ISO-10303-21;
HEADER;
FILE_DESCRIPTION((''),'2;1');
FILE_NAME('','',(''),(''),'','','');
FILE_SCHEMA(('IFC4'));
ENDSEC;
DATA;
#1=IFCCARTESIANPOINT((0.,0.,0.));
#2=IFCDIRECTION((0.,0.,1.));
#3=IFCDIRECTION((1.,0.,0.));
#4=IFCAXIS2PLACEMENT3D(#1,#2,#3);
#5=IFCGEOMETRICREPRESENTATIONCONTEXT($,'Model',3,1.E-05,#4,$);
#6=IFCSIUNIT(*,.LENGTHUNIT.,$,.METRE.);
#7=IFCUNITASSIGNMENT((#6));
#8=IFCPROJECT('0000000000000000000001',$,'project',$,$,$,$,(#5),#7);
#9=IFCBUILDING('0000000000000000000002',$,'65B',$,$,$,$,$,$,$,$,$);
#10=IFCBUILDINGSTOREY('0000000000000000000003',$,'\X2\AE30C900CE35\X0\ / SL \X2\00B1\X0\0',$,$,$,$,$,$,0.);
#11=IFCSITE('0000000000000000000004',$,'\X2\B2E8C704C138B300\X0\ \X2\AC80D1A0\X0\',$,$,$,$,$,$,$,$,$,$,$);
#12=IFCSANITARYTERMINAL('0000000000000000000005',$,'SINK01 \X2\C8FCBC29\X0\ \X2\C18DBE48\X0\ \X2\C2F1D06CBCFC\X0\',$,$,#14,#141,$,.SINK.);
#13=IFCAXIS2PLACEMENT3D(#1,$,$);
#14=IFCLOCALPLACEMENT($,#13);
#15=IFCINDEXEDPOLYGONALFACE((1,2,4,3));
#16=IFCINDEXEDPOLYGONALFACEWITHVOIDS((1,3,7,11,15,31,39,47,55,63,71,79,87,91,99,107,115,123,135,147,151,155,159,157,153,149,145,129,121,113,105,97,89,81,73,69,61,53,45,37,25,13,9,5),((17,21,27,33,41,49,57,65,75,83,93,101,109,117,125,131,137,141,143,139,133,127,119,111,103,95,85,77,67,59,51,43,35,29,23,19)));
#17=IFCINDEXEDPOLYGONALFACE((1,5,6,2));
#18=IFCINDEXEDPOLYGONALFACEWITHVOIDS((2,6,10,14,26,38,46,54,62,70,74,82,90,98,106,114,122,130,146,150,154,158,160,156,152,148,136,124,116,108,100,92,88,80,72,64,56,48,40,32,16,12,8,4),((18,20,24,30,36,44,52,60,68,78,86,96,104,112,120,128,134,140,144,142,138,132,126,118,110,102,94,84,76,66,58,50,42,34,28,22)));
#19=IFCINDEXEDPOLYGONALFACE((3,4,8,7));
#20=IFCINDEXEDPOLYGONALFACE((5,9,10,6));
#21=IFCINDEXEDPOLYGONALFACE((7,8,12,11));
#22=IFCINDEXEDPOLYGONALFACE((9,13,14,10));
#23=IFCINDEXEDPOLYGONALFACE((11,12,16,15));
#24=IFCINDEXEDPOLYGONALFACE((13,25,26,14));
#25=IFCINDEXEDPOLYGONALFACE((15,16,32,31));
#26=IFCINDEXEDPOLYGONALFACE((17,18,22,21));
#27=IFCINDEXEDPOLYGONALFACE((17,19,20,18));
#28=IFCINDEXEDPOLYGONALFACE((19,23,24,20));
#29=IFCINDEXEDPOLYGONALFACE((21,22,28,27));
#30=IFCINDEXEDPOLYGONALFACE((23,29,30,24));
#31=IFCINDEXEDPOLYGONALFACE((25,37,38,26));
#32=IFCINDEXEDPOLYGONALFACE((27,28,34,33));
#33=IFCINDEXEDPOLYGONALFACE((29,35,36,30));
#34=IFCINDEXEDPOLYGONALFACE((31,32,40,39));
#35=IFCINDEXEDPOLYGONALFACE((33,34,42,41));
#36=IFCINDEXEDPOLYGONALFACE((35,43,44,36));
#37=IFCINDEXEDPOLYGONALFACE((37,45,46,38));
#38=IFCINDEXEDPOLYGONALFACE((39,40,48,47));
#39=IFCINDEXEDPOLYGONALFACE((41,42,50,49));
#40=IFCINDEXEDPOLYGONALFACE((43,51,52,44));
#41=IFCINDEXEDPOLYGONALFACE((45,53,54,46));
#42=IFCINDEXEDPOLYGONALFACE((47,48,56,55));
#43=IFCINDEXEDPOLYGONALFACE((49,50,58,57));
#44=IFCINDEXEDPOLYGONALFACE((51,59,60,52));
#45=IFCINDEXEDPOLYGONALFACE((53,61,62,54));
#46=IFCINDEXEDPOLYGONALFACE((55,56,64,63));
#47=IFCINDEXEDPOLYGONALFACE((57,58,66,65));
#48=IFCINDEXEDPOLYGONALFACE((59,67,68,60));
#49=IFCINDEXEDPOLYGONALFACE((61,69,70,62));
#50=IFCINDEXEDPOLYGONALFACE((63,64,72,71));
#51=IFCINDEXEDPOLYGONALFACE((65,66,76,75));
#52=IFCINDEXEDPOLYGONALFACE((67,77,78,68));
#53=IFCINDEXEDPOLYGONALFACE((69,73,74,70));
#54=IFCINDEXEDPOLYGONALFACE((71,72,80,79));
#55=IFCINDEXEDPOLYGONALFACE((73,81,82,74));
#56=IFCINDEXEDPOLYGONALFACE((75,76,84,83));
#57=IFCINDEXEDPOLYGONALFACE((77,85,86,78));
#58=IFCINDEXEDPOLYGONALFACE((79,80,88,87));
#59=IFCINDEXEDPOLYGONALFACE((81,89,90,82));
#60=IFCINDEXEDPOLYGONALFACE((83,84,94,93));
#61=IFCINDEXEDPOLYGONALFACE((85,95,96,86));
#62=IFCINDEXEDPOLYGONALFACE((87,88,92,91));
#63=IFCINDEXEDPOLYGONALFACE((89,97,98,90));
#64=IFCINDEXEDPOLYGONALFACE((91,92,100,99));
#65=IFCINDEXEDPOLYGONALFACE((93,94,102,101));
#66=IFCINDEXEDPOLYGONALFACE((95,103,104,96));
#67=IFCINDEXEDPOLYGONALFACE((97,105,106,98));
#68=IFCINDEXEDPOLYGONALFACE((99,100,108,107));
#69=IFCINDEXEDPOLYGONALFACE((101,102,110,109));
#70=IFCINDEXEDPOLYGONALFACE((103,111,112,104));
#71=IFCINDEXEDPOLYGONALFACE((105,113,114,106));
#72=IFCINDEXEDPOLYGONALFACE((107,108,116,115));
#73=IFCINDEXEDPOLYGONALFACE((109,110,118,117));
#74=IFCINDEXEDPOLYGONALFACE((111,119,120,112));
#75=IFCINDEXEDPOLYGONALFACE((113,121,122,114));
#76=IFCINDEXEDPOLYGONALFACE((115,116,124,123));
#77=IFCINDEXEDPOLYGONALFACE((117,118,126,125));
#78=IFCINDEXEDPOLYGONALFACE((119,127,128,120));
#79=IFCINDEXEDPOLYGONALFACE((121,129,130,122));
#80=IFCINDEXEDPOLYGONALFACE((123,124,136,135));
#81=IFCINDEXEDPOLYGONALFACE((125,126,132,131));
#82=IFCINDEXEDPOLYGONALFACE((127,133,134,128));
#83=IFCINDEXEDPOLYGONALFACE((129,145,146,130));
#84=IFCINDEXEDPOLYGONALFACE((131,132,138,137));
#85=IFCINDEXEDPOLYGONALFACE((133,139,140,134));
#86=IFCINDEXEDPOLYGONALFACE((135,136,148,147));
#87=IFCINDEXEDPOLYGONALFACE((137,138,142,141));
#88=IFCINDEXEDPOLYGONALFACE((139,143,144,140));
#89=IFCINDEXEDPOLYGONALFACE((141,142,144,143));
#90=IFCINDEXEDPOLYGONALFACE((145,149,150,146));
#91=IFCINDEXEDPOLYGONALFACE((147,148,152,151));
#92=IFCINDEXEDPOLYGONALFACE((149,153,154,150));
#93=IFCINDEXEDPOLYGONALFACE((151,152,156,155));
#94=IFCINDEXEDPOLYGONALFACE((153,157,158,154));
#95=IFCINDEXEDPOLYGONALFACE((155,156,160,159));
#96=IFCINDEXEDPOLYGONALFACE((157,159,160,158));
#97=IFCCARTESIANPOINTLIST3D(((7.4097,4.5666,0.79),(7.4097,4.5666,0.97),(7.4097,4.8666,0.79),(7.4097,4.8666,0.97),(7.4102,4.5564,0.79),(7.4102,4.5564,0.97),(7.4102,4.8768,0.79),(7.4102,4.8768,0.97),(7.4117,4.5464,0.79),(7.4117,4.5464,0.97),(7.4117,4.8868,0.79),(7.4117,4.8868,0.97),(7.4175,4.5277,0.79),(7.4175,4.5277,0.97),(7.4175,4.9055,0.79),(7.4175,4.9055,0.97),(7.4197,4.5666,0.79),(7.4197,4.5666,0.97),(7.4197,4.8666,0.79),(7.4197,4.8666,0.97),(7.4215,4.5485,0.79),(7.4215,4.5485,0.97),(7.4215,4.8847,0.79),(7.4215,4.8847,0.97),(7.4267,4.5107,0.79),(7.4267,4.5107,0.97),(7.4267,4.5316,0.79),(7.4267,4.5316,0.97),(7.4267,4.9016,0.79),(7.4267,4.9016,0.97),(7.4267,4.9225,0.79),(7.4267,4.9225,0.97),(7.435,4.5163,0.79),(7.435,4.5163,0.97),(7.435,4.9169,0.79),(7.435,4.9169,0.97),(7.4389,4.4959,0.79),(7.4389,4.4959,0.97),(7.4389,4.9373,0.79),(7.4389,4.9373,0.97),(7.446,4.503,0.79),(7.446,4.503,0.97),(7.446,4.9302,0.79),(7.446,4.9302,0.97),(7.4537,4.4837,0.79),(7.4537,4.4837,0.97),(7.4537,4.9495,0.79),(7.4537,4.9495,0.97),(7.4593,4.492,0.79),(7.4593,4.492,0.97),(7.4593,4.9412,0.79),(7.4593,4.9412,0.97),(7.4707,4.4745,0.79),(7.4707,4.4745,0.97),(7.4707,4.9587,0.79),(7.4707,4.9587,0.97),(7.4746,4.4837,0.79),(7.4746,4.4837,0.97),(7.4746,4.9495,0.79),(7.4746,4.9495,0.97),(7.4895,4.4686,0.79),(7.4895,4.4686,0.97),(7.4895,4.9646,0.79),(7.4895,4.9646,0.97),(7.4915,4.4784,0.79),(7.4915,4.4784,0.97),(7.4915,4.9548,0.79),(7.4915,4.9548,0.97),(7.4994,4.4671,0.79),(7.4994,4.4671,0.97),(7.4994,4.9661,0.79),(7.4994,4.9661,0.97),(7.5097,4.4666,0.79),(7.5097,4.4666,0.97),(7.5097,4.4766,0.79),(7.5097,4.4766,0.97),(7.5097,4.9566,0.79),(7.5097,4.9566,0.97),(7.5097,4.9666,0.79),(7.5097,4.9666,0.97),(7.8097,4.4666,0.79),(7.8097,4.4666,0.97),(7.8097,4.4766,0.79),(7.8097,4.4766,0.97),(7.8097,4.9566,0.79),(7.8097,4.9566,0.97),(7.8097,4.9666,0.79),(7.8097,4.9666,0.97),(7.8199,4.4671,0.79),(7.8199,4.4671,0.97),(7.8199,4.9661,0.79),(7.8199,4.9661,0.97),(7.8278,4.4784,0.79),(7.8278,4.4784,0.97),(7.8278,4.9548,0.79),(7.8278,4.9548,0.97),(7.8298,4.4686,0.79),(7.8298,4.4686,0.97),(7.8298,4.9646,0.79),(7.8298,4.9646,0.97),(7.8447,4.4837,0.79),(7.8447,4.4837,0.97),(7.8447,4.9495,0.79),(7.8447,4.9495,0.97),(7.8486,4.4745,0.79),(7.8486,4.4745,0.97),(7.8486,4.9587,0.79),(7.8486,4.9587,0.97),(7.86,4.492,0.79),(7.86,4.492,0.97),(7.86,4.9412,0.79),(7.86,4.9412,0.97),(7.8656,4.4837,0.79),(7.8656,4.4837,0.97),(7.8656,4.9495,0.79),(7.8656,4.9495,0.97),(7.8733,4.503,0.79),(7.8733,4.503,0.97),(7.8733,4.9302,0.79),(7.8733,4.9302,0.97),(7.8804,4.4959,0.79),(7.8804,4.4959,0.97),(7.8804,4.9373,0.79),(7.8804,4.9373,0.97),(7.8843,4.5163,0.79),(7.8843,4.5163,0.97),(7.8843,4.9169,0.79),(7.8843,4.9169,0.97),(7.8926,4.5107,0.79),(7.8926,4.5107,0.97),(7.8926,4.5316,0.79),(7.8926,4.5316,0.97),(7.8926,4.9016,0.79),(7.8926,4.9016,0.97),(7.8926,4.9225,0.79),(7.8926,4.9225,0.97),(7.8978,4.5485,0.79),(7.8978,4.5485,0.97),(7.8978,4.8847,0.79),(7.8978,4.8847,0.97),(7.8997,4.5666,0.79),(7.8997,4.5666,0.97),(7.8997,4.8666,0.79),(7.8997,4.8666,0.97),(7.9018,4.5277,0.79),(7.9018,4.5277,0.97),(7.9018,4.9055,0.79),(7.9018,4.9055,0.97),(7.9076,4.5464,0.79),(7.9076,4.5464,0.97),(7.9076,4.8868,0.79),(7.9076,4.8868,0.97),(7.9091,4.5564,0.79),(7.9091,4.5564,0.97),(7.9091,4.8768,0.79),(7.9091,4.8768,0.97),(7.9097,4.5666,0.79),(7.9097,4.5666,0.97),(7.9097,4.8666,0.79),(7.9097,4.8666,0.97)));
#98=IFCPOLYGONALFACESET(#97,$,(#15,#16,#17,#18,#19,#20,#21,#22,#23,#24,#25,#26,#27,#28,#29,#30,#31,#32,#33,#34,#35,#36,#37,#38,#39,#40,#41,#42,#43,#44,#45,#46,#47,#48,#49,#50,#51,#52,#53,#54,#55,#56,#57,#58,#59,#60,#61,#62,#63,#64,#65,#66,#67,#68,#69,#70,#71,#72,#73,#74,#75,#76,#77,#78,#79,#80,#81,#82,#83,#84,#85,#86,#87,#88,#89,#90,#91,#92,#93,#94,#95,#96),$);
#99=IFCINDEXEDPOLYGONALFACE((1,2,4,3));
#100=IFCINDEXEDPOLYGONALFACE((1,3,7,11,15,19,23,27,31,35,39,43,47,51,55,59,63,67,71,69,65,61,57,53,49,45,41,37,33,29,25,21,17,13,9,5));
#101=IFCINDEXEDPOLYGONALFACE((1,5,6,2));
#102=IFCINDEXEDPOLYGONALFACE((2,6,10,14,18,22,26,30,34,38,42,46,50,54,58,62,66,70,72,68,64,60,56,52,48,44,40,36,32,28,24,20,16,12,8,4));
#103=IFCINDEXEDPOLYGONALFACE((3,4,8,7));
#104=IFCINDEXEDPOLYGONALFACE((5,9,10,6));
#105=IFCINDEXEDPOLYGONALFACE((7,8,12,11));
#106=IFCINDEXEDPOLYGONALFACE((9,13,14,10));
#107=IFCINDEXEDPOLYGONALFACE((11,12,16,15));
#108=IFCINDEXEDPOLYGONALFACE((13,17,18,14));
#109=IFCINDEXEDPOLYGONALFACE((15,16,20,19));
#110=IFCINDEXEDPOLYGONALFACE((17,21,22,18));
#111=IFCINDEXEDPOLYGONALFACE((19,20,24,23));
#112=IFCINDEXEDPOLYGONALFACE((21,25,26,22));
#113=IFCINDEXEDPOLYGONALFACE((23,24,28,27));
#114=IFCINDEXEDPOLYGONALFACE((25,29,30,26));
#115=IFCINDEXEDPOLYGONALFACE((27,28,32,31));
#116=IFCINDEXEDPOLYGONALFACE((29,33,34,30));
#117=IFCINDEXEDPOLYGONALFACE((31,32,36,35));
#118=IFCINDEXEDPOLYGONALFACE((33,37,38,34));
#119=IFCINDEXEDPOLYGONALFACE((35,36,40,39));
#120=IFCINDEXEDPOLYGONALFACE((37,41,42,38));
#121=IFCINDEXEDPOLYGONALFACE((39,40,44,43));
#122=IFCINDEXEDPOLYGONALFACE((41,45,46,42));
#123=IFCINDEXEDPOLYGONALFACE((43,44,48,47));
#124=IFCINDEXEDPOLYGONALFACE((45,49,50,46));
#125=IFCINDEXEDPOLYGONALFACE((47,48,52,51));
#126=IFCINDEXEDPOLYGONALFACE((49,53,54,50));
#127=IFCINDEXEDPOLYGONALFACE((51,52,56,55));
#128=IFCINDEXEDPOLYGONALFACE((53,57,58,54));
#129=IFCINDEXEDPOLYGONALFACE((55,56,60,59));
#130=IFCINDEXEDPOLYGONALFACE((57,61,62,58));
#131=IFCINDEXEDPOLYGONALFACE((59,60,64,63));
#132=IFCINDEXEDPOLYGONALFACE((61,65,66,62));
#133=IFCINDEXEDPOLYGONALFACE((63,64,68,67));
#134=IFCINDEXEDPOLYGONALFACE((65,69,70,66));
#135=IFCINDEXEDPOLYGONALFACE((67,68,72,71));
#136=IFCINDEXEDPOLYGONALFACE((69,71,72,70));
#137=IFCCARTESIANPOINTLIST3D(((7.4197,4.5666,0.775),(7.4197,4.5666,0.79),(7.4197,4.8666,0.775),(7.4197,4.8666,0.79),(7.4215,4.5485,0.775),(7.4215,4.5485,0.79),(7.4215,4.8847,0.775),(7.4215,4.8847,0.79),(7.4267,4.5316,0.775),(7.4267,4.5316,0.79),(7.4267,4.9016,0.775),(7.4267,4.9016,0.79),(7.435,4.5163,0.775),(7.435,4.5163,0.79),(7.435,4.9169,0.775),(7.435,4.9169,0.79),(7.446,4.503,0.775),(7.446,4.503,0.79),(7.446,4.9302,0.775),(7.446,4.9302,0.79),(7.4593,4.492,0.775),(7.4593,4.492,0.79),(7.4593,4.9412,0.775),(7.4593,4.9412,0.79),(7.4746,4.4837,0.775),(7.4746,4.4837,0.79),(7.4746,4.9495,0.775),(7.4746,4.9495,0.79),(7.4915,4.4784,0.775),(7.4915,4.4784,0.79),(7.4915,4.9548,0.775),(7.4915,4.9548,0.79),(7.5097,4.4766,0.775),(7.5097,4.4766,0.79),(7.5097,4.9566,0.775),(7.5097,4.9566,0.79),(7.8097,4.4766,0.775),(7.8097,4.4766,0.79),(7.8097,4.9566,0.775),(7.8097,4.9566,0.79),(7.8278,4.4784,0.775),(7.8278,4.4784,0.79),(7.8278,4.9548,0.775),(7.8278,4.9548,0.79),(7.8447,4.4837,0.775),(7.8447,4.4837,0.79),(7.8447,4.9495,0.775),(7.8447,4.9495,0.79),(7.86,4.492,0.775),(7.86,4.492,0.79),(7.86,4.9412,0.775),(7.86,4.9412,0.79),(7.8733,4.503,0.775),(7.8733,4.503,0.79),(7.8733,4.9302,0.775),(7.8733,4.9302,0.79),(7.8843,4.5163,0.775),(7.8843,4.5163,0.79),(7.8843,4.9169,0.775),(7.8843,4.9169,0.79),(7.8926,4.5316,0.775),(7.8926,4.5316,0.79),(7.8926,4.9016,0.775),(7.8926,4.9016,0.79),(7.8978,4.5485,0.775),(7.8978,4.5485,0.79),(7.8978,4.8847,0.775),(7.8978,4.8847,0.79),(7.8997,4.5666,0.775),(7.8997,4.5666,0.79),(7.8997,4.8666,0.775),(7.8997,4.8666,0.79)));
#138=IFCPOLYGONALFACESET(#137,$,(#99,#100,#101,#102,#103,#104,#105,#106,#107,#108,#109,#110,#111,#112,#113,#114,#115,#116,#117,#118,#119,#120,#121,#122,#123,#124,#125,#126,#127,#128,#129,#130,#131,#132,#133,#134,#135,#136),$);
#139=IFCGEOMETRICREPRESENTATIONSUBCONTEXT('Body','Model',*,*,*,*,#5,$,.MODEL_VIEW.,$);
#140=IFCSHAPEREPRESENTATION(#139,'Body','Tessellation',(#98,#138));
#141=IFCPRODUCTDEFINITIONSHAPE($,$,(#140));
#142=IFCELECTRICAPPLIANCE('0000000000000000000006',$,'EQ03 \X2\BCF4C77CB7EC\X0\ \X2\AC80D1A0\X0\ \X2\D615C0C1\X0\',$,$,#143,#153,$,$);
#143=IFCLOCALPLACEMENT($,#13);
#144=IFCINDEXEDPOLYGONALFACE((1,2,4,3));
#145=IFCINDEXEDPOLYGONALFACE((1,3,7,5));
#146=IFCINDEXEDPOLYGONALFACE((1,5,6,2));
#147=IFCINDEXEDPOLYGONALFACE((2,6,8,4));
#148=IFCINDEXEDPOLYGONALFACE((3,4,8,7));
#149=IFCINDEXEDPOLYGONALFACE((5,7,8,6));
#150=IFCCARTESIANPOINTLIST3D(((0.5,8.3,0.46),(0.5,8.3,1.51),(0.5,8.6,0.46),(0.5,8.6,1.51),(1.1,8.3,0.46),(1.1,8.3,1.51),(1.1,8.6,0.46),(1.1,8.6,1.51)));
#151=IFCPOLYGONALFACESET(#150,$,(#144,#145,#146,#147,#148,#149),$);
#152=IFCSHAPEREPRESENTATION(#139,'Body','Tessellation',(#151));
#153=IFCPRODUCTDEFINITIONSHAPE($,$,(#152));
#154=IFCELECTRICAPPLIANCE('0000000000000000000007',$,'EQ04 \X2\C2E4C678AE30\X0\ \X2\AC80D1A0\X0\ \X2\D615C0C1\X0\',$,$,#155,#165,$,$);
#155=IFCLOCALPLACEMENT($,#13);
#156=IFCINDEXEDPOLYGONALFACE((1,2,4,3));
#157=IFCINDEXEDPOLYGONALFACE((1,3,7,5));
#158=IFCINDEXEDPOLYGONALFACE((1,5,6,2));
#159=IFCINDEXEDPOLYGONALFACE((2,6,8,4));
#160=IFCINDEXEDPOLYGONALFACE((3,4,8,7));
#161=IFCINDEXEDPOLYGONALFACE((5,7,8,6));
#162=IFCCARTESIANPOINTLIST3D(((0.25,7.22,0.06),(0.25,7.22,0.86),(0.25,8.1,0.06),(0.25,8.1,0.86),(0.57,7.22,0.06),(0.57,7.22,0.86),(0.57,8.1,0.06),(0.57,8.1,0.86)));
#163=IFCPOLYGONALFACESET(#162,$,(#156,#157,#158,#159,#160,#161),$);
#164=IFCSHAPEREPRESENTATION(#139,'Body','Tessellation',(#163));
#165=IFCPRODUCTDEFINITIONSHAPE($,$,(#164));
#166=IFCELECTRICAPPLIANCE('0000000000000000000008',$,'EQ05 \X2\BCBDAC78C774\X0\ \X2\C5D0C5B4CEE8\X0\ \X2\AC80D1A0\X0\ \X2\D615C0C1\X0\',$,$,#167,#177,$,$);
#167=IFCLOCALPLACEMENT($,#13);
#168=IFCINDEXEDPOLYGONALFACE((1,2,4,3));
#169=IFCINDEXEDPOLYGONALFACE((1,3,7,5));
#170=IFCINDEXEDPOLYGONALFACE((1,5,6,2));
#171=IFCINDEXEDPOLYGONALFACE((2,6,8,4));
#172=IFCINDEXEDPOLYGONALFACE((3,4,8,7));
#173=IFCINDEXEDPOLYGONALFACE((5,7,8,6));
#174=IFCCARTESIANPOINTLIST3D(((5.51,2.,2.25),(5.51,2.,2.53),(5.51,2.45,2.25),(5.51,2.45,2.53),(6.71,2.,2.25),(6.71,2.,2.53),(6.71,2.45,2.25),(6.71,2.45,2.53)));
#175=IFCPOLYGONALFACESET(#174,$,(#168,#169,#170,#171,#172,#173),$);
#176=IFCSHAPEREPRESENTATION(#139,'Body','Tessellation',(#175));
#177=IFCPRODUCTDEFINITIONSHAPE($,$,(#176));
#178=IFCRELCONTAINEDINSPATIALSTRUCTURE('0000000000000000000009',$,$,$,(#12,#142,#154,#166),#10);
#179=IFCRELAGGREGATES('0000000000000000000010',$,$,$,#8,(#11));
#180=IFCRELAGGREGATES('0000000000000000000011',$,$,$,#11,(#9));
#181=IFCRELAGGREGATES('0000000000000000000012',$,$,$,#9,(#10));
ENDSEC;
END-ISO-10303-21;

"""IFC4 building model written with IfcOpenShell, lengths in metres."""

from ifc_helpers import new_model, si_unit, frame, origin_with_axes, place, context, subcontext, project, spatial, polyline, outline, extrude, element, save


model = new_model("IFC4")

# Units and contexts
model_context = context("Model", 3, precision=1e-05, world=origin_with_axes())
body_context = subcontext(model_context, "Body", "Model", "MODEL_VIEW")
ifc_project = project(units=[si_unit("LENGTHUNIT", "METRE")], contexts=[model_context])

# Site, building, storey
site = spatial("IfcSite", under=ifc_project, Name="단위세대 검토")
building = spatial("IfcBuilding", under=site, Name="65B")
storey = spatial("IfcBuildingStorey", under=building, Name="기준층 / SL ±0", Elevation=0.0)

# Sanitary terminal
sanitary_terminal_placement = place(None, origin_with_axes())
element("IfcSanitaryTerminal", 1, at=sanitary_terminal_placement, inside=storey, Name="SINK01 주방 속빈 싱크볼", PredefinedType="SINK", context=body_context, shape_type="SweptSolid", body=[
    extrude(outline(polyline([(7.4097, 4.8666), (7.4102, 4.8768), (7.4117, 4.8868), (7.4175, 4.9055), (7.4267, 4.9225), (7.4389, 4.9373), (7.4537, 4.9495), (7.4707, 4.9587), (7.4895, 4.9646), (7.4994, 4.9661), (7.5097, 4.9666), (7.8097, 4.9666), (7.8199, 4.9661), (7.8298, 4.9646), (7.8486, 4.9587), (7.8656, 4.9495), (7.8804, 4.9373), (7.8926, 4.9225), (7.9018, 4.9055), (7.9076, 4.8868), (7.9091, 4.8768), (7.9097, 4.8666), (7.9097, 4.5666), (7.9091, 4.5564), (7.9076, 4.5464), (7.9018, 4.5277), (7.8926, 4.5107), (7.8804, 4.4959), (7.8656, 4.4837), (7.8486, 4.4745), (7.8298, 4.4686), (7.8199, 4.4671), (7.8097, 4.4666), (7.5097, 4.4666), (7.4994, 4.4671), (7.4895, 4.4686), (7.4707, 4.4745), (7.4537, 4.4837), (7.4389, 4.4959), (7.4267, 4.5107), (7.4175, 4.5277), (7.4117, 4.5464), (7.4102, 4.5564), (7.4097, 4.5666), (7.4097, 4.8666)]), holes=[polyline([(7.4215, 4.5485), (7.4267, 4.5316), (7.435, 4.5163), (7.446, 4.503), (7.4593, 4.492), (7.4746, 4.4837), (7.4915, 4.4784), (7.5097, 4.4766), (7.8097, 4.4766), (7.8278, 4.4784), (7.8447, 4.4837), (7.86, 4.492), (7.8733, 4.503), (7.8843, 4.5163), (7.8926, 4.5316), (7.8978, 4.5485), (7.8997, 4.5666), (7.8997, 4.8666), (7.8978, 4.8847), (7.8926, 4.9016), (7.8843, 4.9169), (7.8733, 4.9302), (7.86, 4.9412), (7.8447, 4.9495), (7.8278, 4.9548), (7.8097, 4.9566), (7.5097, 4.9566), (7.4915, 4.9548), (7.4746, 4.9495), (7.4593, 4.9412), (7.446, 4.9302), (7.435, 4.9169), (7.4267, 4.9016), (7.4215, 4.8847), (7.4197, 4.8666), (7.4197, 4.5666), (7.4215, 4.5485)])]), frame((0.0, 0.0, 0.79)), (0.0, 0.0, 1.0), 0.18),
    extrude(outline(polyline([(7.4197, 4.5666), (7.4197, 4.8666), (7.4215, 4.8847), (7.4267, 4.9016), (7.435, 4.9169), (7.446, 4.9302), (7.4593, 4.9412), (7.4746, 4.9495), (7.4915, 4.9548), (7.5097, 4.9566), (7.8097, 4.9566), (7.8278, 4.9548), (7.8447, 4.9495), (7.86, 4.9412), (7.8733, 4.9302), (7.8843, 4.9169), (7.8926, 4.9016), (7.8978, 4.8847), (7.8997, 4.8666), (7.8997, 4.5666), (7.8978, 4.5485), (7.8926, 4.5316), (7.8843, 4.5163), (7.8733, 4.503), (7.86, 4.492), (7.8447, 4.4837), (7.8278, 4.4784), (7.8097, 4.4766), (7.5097, 4.4766), (7.4915, 4.4784), (7.4746, 4.4837), (7.4593, 4.492), (7.446, 4.503), (7.435, 4.5163), (7.4267, 4.5316), (7.4215, 4.5485), (7.4197, 4.5666)])), frame((0.0, 0.0, 0.775)), (0.0, 0.0, 1.0), 0.015),
])

# Electric appliances
electric_appliance_1_placement = place(None, origin_with_axes())
element("IfcElectricAppliance", 2, at=electric_appliance_1_placement, inside=storey, Name="EQ03 보일러 검토 형상", context=body_context, shape_type="SweptSolid", body=[
    extrude(outline(polyline([(0.5, 8.3), (0.5, 8.6), (1.1, 8.6), (1.1, 8.3), (0.5, 8.3)])), frame((0.0, 0.0, 0.46)), (0.0, 0.0, 1.0), 1.05),
])
electric_appliance_2_placement = place(None, origin_with_axes())
element("IfcElectricAppliance", 3, at=electric_appliance_2_placement, inside=storey, Name="EQ04 실외기 검토 형상", context=body_context, shape_type="SweptSolid", body=[
    extrude(outline(polyline([(0.57, 8.1), (0.57, 7.22), (0.25, 7.22), (0.25, 8.1), (0.57, 8.1)])), frame((0.0, 0.0, 0.06)), (0.0, 0.0, 1.0), 0.8),
])
electric_appliance_3_placement = place(None, origin_with_axes())
element("IfcElectricAppliance", 4, at=electric_appliance_3_placement, inside=storey, Name="EQ05 벽걸이 에어컨 검토 형상", context=body_context, shape_type="SweptSolid", body=[
    extrude(outline(polyline([(5.51, 2.45), (6.71, 2.45), (6.71, 2.0), (5.51, 2.0), (5.51, 2.45)])), frame((0.0, 0.0, 2.25)), (0.0, 0.0, 1.0), 0.28),
])

save(model, "model.ifc")
